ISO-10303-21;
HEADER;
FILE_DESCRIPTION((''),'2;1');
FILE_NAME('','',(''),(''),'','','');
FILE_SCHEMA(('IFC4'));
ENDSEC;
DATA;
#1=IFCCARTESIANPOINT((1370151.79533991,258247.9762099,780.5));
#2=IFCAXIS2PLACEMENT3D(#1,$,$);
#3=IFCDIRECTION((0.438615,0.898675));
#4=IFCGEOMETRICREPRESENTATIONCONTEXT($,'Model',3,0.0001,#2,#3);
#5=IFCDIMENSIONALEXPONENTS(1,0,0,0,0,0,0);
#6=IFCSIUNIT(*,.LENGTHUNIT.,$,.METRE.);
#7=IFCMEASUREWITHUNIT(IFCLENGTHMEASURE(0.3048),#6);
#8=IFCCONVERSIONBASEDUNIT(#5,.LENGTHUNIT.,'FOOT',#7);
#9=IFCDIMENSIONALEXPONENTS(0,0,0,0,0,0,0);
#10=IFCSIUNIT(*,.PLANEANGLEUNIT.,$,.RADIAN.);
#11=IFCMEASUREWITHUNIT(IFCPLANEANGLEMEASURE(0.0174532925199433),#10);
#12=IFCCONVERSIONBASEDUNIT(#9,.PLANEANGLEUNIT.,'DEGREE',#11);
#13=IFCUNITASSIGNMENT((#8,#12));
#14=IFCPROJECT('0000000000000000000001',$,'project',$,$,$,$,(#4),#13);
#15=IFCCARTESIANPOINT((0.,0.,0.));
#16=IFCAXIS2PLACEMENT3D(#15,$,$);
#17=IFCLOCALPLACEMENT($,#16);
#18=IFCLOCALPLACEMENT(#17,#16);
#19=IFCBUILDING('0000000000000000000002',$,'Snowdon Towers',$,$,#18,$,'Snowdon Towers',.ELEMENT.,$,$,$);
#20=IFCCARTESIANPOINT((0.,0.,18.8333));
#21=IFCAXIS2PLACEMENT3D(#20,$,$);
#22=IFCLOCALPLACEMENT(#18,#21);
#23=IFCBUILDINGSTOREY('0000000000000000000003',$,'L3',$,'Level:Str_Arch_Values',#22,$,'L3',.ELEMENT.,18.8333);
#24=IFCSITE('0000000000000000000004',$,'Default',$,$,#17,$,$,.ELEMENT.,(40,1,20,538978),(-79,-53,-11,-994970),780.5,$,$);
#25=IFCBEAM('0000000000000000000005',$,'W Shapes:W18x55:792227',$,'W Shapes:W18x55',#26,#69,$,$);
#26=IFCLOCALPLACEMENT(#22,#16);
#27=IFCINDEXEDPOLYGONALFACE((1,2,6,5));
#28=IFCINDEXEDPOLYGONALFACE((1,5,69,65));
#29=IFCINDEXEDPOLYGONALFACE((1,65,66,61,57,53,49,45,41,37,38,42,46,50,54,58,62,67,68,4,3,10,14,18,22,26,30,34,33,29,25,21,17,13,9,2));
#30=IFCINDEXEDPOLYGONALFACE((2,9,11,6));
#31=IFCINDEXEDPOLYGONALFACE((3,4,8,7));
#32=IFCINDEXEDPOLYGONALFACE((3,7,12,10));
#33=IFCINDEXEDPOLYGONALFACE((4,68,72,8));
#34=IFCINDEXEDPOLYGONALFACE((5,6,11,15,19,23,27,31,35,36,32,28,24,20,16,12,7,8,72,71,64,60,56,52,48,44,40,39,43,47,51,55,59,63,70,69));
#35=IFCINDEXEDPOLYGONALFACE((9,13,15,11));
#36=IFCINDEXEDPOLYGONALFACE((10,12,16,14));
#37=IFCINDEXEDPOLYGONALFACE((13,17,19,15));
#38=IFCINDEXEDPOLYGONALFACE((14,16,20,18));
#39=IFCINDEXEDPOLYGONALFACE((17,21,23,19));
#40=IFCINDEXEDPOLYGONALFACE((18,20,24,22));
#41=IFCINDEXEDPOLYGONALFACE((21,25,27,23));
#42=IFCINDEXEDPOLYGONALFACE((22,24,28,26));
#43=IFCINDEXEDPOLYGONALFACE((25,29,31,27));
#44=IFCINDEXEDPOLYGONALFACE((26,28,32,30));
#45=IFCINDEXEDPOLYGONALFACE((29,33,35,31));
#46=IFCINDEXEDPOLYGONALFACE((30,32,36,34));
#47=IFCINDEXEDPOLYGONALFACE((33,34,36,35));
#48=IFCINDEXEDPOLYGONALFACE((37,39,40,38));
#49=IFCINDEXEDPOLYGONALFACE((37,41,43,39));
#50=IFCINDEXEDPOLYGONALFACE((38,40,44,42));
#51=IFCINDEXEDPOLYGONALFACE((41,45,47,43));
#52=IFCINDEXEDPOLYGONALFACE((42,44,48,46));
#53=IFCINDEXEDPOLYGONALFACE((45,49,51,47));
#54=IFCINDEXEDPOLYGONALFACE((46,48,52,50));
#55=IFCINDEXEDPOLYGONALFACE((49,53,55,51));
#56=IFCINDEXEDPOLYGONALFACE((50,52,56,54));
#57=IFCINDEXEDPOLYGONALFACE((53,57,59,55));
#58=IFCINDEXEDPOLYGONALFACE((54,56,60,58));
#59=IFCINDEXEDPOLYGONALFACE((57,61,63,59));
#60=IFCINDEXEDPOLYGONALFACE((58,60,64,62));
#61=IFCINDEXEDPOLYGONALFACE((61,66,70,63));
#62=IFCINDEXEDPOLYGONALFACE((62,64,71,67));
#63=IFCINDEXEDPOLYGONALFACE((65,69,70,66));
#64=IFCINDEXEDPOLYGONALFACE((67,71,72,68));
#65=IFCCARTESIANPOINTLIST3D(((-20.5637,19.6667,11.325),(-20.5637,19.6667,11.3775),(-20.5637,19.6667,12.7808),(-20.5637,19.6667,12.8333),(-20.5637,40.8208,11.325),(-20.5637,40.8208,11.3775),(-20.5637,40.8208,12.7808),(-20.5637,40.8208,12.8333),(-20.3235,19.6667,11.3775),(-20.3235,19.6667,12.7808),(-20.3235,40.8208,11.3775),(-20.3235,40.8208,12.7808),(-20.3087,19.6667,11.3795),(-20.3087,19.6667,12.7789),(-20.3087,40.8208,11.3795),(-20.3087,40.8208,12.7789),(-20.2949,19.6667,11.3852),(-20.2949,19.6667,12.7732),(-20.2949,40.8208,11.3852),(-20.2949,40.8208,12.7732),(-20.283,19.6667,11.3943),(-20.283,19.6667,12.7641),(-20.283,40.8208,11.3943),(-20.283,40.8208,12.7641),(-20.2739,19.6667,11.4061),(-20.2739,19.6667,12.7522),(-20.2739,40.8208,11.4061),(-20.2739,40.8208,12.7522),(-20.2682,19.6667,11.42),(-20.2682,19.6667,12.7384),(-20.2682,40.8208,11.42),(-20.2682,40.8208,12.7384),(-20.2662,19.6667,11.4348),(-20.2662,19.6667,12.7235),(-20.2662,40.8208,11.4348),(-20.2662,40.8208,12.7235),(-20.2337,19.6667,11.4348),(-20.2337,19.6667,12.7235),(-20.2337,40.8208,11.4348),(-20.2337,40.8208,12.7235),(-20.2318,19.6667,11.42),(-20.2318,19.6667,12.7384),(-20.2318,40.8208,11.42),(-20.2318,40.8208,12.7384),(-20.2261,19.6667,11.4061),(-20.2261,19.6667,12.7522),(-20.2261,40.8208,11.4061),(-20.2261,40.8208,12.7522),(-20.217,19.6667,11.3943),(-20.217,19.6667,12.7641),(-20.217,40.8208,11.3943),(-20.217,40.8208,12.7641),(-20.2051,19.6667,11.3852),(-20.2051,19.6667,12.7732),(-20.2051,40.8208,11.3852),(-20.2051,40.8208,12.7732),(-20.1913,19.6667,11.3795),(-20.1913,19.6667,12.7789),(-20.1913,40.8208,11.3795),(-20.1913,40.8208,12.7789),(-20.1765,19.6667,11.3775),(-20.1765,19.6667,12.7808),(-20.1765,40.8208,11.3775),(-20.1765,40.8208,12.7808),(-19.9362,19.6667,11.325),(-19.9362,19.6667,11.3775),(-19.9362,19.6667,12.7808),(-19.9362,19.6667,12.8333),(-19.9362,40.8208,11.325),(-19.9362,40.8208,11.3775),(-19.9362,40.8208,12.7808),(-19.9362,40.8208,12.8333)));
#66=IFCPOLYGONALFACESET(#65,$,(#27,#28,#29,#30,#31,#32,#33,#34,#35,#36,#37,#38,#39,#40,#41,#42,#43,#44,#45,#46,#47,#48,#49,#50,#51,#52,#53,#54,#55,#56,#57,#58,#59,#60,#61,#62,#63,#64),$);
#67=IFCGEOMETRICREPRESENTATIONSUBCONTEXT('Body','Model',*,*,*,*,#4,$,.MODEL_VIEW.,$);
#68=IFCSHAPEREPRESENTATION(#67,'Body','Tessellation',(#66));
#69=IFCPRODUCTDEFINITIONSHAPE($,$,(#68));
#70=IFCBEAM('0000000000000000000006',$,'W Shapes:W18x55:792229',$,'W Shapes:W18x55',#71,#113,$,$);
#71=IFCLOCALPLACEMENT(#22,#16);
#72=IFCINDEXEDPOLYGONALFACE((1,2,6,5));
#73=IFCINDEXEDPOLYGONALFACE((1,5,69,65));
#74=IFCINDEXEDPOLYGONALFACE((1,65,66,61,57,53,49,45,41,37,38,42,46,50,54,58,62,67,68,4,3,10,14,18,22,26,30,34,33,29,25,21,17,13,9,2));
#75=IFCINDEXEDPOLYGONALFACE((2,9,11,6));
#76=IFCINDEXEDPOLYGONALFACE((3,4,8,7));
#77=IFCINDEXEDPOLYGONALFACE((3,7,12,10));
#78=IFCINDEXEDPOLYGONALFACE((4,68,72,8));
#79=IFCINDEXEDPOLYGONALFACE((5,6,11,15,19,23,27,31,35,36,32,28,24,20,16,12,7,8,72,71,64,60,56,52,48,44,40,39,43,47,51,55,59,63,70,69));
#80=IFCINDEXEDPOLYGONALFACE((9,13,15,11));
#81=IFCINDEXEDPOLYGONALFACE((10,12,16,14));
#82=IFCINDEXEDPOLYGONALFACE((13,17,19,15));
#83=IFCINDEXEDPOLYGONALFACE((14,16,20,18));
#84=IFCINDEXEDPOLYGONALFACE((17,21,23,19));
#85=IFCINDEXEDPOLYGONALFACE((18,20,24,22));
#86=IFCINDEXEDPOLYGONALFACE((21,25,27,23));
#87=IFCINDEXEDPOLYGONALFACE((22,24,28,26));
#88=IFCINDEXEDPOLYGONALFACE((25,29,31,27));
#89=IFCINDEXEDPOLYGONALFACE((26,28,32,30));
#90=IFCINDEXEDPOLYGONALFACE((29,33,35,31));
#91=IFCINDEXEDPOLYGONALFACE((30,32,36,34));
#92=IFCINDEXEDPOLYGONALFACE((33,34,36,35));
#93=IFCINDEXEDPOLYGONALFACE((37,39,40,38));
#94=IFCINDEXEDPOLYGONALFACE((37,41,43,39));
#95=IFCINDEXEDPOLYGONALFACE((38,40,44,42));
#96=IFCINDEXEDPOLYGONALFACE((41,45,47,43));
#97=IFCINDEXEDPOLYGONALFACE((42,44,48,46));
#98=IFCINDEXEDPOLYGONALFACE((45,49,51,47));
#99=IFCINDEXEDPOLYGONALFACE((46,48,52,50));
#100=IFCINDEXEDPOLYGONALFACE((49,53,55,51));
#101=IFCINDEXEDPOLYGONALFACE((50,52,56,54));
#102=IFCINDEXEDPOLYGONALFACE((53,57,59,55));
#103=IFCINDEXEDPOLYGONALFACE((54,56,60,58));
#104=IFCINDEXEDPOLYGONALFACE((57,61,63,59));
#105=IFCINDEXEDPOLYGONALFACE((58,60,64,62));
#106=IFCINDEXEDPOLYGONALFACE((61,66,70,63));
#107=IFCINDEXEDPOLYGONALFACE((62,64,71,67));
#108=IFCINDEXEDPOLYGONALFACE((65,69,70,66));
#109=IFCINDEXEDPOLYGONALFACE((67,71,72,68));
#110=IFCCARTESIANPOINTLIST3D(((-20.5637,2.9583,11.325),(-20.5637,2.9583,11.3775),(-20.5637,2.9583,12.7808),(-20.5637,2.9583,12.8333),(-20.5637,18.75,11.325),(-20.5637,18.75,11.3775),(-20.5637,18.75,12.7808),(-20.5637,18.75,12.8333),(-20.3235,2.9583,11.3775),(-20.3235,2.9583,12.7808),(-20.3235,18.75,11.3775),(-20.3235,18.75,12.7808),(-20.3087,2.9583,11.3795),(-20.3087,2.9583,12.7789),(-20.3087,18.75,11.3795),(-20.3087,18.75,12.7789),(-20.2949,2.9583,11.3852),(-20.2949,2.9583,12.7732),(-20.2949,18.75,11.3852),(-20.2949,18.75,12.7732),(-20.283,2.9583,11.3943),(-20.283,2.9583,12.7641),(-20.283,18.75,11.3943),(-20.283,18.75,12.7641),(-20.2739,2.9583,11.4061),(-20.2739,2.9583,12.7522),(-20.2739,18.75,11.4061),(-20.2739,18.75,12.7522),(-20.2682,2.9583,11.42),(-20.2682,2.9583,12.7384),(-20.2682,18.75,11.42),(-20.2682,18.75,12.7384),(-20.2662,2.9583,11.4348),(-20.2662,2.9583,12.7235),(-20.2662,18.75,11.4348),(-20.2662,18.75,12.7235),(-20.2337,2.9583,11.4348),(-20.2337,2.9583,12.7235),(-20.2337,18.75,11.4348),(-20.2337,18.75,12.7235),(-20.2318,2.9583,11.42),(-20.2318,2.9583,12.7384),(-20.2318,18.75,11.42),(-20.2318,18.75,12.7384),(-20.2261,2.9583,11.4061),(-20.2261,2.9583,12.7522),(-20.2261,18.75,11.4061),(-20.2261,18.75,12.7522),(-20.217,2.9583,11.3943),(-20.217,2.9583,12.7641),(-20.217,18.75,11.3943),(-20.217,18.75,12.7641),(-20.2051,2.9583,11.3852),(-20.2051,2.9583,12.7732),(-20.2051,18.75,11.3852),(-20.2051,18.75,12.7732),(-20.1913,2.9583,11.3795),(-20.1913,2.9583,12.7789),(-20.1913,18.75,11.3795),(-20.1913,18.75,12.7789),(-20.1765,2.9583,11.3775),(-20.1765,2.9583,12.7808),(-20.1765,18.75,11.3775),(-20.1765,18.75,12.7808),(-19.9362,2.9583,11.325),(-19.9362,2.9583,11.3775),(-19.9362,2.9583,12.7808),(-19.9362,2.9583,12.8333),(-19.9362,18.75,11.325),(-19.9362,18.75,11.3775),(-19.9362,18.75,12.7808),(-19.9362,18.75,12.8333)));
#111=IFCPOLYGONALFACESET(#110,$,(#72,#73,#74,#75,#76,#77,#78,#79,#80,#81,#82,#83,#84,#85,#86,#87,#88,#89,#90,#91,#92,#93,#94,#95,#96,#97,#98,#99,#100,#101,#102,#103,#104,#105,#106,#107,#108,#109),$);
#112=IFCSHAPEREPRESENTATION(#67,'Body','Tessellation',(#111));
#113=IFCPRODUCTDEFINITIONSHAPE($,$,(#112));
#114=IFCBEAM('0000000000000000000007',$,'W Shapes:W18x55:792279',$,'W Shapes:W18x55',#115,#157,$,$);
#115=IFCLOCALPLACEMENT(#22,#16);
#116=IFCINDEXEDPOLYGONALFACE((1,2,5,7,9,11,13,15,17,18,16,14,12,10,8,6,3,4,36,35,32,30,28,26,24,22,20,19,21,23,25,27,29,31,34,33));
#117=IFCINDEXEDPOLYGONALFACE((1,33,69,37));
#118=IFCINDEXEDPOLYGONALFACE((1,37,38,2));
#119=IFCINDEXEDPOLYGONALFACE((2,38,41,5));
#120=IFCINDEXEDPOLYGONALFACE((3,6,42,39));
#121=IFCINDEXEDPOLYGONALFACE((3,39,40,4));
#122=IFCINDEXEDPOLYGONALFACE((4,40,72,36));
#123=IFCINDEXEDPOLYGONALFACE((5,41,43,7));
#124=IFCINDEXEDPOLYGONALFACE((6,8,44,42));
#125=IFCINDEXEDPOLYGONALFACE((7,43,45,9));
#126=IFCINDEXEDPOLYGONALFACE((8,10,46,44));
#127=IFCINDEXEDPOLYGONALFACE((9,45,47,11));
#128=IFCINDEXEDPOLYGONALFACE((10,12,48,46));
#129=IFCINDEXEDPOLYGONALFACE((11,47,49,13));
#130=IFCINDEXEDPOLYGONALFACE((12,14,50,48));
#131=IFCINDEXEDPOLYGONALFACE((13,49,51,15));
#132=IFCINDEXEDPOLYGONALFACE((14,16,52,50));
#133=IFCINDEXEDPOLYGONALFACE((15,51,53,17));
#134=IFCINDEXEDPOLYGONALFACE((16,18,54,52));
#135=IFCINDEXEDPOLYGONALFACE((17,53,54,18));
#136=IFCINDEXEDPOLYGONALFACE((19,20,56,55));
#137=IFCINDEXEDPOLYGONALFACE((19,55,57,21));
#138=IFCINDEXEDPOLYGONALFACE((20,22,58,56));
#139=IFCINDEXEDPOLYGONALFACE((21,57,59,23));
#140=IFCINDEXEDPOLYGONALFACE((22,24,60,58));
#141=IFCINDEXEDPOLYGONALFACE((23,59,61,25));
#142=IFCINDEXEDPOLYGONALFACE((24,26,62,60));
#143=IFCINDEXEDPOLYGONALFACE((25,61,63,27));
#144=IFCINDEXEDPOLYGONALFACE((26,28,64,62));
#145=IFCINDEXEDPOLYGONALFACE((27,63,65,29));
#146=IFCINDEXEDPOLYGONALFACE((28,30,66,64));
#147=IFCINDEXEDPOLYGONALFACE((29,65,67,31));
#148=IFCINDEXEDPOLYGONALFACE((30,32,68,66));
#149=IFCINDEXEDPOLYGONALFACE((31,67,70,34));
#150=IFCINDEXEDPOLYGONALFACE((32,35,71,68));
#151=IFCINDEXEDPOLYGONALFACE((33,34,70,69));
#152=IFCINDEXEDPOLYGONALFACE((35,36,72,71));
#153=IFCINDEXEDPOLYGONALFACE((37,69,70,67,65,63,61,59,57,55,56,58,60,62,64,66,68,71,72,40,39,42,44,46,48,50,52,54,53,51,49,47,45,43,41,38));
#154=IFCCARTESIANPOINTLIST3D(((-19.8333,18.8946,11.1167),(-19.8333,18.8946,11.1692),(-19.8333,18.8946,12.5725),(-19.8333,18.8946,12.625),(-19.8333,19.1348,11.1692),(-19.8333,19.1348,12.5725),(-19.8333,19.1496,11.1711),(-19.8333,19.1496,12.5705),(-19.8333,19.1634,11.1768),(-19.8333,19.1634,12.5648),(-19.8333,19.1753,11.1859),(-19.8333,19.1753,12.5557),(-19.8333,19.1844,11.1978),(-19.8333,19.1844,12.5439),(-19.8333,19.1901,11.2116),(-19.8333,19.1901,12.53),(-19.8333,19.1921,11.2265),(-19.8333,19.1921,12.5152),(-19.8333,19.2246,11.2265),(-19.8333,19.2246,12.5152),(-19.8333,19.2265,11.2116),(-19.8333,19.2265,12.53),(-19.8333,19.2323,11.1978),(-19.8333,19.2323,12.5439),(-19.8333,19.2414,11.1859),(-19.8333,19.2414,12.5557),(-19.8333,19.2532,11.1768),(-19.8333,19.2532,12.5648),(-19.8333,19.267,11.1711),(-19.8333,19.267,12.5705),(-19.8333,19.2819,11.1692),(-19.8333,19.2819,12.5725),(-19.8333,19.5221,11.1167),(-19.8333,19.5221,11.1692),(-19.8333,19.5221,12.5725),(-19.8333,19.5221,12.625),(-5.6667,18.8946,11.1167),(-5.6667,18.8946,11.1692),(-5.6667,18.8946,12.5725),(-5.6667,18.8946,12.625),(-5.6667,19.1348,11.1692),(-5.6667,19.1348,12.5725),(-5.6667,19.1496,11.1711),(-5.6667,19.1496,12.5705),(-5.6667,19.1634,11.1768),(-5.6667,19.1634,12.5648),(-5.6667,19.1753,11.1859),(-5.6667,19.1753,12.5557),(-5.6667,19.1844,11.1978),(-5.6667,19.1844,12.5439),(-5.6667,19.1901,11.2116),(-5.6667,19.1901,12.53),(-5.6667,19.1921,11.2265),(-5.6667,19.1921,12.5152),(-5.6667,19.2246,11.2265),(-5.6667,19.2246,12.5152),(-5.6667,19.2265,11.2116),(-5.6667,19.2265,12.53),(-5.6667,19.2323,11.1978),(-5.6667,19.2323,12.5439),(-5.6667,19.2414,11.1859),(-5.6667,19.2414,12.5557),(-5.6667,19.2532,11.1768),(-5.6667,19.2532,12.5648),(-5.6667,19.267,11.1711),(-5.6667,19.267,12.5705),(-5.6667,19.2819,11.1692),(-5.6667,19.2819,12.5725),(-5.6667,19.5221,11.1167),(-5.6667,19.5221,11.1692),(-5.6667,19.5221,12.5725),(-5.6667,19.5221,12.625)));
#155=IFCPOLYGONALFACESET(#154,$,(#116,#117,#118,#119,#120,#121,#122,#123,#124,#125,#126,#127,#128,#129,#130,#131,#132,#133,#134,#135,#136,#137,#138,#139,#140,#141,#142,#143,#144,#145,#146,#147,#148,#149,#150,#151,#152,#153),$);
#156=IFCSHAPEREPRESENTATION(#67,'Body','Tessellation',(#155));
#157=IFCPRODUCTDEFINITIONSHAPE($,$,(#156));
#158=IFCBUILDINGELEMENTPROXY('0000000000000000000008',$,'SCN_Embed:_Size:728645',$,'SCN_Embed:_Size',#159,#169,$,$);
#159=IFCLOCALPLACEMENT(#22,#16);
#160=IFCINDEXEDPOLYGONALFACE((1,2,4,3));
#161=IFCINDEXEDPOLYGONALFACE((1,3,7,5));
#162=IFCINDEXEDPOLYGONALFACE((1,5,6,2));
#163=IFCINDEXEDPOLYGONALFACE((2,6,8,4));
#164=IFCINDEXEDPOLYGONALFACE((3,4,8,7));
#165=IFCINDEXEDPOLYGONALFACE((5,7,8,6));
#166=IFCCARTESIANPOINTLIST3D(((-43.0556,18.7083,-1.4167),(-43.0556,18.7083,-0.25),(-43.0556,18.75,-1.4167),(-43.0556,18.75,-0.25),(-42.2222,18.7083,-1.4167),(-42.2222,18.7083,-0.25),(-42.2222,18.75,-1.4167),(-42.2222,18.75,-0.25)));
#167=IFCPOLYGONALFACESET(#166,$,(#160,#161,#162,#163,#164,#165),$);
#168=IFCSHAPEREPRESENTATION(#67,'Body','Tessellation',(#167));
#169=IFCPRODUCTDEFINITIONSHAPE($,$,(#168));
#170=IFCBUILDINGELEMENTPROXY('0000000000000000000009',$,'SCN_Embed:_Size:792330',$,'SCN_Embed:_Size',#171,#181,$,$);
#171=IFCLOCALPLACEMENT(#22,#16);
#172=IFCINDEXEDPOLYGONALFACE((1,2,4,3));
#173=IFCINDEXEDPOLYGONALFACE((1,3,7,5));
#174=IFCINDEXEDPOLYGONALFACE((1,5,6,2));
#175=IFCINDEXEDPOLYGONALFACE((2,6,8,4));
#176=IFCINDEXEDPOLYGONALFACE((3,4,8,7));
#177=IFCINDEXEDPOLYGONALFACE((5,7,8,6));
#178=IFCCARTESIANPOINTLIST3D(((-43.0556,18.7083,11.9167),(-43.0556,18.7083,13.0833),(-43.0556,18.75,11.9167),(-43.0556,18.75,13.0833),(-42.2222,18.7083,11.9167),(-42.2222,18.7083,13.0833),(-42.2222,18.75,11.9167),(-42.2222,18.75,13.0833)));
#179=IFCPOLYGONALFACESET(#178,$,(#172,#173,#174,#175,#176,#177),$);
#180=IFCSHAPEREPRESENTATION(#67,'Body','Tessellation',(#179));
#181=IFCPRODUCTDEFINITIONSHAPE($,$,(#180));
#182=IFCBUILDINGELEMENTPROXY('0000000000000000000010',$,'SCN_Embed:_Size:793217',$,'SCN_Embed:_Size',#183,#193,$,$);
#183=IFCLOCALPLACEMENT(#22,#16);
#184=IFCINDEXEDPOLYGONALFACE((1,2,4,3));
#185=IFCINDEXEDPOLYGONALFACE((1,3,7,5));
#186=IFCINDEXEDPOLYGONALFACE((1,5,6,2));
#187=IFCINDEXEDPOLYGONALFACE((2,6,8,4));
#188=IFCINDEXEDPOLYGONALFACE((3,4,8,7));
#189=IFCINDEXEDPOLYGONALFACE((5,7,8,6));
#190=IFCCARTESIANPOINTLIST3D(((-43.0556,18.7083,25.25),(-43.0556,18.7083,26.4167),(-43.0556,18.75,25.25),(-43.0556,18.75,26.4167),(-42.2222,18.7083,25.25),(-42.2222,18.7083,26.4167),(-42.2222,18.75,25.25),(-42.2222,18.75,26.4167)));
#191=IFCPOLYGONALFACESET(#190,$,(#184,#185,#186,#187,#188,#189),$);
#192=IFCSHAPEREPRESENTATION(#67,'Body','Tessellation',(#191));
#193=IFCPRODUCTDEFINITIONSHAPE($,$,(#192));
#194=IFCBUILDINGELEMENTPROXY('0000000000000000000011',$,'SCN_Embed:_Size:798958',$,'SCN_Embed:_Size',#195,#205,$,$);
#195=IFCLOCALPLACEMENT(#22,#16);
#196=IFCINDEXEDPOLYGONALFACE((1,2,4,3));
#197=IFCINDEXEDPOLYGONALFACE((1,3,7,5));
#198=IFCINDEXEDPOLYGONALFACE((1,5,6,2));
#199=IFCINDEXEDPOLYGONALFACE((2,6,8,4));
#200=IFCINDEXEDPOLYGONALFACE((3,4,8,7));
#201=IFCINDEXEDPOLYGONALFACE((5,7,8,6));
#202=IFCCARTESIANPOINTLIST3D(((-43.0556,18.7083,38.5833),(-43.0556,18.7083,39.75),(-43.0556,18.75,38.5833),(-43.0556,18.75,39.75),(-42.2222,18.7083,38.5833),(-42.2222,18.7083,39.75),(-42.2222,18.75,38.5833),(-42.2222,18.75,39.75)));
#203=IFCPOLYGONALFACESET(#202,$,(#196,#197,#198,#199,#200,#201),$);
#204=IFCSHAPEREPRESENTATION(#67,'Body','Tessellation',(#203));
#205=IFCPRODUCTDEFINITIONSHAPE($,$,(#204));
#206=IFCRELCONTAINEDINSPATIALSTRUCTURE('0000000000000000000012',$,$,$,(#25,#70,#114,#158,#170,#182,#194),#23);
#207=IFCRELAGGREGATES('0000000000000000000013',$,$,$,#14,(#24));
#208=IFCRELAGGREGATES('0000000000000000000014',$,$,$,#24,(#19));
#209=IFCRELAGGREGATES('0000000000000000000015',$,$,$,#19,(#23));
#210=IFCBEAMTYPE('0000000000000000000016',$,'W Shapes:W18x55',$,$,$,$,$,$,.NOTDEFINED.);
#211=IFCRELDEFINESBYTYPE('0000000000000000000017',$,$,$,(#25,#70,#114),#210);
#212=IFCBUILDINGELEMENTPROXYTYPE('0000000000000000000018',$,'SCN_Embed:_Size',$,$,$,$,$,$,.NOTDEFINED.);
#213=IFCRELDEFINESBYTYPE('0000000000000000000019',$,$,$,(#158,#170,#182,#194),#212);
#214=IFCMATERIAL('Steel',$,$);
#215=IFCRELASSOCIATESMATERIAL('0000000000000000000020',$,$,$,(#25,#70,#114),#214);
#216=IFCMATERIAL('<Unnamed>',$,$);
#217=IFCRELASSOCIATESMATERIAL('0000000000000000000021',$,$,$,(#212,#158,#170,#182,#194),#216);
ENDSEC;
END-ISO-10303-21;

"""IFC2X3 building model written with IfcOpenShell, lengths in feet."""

from ifc_helpers import new_model, entity, si_unit, converted_unit, direction, frame, frame_2d, origin, place, context, subcontext, project, spatial, rectangle, i_section, extrude, source, transform, mapped, material, type_object, type_shapes, element, save


model = new_model("IFC2X3")

# Units and contexts
model_context = context("Model", 3, precision=0.0001, world=frame((1370151.79533991, 258247.9762099, 780.5)), true_north=direction((0.438615, 0.898675)))
body_context = subcontext(model_context, "Body", "Model", "MODEL_VIEW")
ifc_project = project(units=[converted_unit("LENGTHUNIT", "FOOT", entity("IfcLengthMeasure", 0.3048), si_unit("LENGTHUNIT", "METRE"), dimensions=[1, 0, 0, 0, 0, 0, 0]), converted_unit("PLANEANGLEUNIT", "DEGREE", entity("IfcPlaneAngleMeasure", 0.0174532925199433), si_unit("PLANEANGLEUNIT", "RADIAN"), dimensions=[0, 0, 0, 0, 0, 0, 0])], contexts=[model_context])

# Site, building, storey
site_placement = place(None, origin())
site = spatial("IfcSite", under=ifc_project, at=site_placement, Name="Default", CompositionType="ELEMENT", RefLatitude=(40, 1, 20, 538978), RefLongitude=(-79, -53, -11, -994970), RefElevation=780.5)
building_placement = place(site_placement, origin())
building = spatial("IfcBuilding", under=site, at=building_placement, Name="Snowdon Towers", LongName="Snowdon Towers", CompositionType="ELEMENT")
storey_placement = place(building_placement, frame((0.0, 0.0, 18.8333)))
storey = spatial("IfcBuildingStorey", under=building, at=storey_placement, Name="L3", ObjectType="Level:Str_Arch_Values", LongName="L3", CompositionType="ELEMENT", Elevation=18.8333)

# Beams
ifc_material_1 = material(Name="Steel")
beam_type = type_object("IfcBeamType", Name="W Shapes:W18x55", PredefinedType="NOTDEFINED")
beam_1_placement = place(storey_placement, frame((-20.25, 41.625, 12.8333), z_axis=(0.0, 0.0, 1.0), x_axis=(0.0, -1.0, 0.0)))
element("IfcBeam", 1, at=beam_1_placement, inside=storey, type_object=beam_type, material=ifc_material_1, Name="W Shapes:W18x55:792227", ObjectType="W Shapes:W18x55", context=body_context, shape_type="SweptSolid", body=[
    extrude(i_section(OverallWidth=0.6275, OverallDepth=1.5083, WebThickness=0.0325, FlangeThickness=0.0525, FilletRadius=0.0573, at=frame_2d((0.0, 0.0), x_axis=(0.0, 1.0))), frame((0.8042, 0.0, -0.7542), z_axis=(1.0, 0.0, 0.0), x_axis=(0.0, 0.0, -1.0)), (0.0, 0.0, 1.0), 21.1542),
])
beam_2_placement = place(storey_placement, frame((-20.25, 19.2083, 12.8333), z_axis=(0.0, 0.0, 1.0), x_axis=(0.0, -1.0, 0.0)))
element("IfcBeam", 2, at=beam_2_placement, inside=storey, type_object=beam_type, material=ifc_material_1, Name="W Shapes:W18x55:792229", ObjectType="W Shapes:W18x55", context=body_context, shape_type="SweptSolid", body=[
    extrude(i_section(OverallWidth=0.6275, OverallDepth=1.5083, WebThickness=0.0325, FlangeThickness=0.0525, FilletRadius=0.0573, at=frame_2d((0.0, 0.0), x_axis=(0.0, 1.0))), frame((0.4583, 0.0, -0.7542), z_axis=(1.0, 0.0, 0.0), x_axis=(0.0, 0.0, -1.0)), (0.0, 0.0, 1.0), 15.7917),
])
beam_3_placement = place(storey_placement, frame((-5.6667, 19.2083, 12.8333), z_axis=(0.0, 0.0, 1.0), x_axis=(-1.0, 0.0, 0.0)))
element("IfcBeam", 3, at=beam_3_placement, inside=storey, type_object=beam_type, material=ifc_material_1, Name="W Shapes:W18x55:792279", ObjectType="W Shapes:W18x55", context=body_context, shape_type="SweptSolid", body=[
    extrude(i_section(OverallWidth=0.6275, OverallDepth=1.5083, WebThickness=0.0325, FlangeThickness=0.0525, FilletRadius=0.0573, at=frame_2d((0.0, 0.0), x_axis=(0.0, 1.0))), frame((0.0, 0.0, -0.9625), z_axis=(1.0, 0.0, 0.0), x_axis=(0.0, 0.0, -1.0)), (0.0, 0.0, 1.0), 14.1667),
])

# Building element proxies
ifc_material_2 = material(Name="<Unnamed>")
building_element_proxy_type_1 = type_object("IfcBuildingElementProxyType", Name="SCN_Embed:_Size", PredefinedType="NOTDEFINED", material=ifc_material_2)
shared_shape_1 = source(origin(), body_context, "Body", "SweptSolid", [
    extrude(rectangle(XDim=0.8333, YDim=1.1667, at=frame_2d((0.0, 0.0), x_axis=(1.0, 0.0))), frame((0.0, 0.0, -0.0417), z_axis=(0.0, 0.0, 1.0), x_axis=(-1.0, 0.0, 0.0)), (0.0, 0.0, 1.0), 0.0417),
])
type_shapes(building_element_proxy_type_1, [shared_shape_1])
for number, where, z_axis, x_axis, name in (
    (4, (-42.6389, 18.7083, -0.8333), (0.0, -1.0, 0.0), (1.0, 0.0, 0.0), "SCN_Embed:_Size:728645"),
    (5, (-42.6389, 18.7083, 12.5), (0.0, -1.0, 0.0), (1.0, 0.0, 0.0), "SCN_Embed:_Size:792330"),
    (6, (-42.6389, 18.7083, 25.8333), (0.0, -1.0, 0.0), (1.0, 0.0, 0.0), "SCN_Embed:_Size:793217"),
    (7, (-42.6389, 18.7083, 39.1667), (0.0, -1.0, 0.0), (1.0, 0.0, 0.0), "SCN_Embed:_Size:798958"),
):
    element("IfcBuildingElementProxy", number, at=place(storey_placement, frame(where, z_axis=z_axis, x_axis=x_axis)), inside=storey, type_object=building_element_proxy_type_1, material=ifc_material_2, Name=name, ObjectType="SCN_Embed:_Size", context=body_context, shape_type="MappedRepresentation", body=[
        mapped(shared_shape_1, transform((0.0, 0.0, 0.0), scale=1.0)),
    ])

save(model, "model.ifc")
